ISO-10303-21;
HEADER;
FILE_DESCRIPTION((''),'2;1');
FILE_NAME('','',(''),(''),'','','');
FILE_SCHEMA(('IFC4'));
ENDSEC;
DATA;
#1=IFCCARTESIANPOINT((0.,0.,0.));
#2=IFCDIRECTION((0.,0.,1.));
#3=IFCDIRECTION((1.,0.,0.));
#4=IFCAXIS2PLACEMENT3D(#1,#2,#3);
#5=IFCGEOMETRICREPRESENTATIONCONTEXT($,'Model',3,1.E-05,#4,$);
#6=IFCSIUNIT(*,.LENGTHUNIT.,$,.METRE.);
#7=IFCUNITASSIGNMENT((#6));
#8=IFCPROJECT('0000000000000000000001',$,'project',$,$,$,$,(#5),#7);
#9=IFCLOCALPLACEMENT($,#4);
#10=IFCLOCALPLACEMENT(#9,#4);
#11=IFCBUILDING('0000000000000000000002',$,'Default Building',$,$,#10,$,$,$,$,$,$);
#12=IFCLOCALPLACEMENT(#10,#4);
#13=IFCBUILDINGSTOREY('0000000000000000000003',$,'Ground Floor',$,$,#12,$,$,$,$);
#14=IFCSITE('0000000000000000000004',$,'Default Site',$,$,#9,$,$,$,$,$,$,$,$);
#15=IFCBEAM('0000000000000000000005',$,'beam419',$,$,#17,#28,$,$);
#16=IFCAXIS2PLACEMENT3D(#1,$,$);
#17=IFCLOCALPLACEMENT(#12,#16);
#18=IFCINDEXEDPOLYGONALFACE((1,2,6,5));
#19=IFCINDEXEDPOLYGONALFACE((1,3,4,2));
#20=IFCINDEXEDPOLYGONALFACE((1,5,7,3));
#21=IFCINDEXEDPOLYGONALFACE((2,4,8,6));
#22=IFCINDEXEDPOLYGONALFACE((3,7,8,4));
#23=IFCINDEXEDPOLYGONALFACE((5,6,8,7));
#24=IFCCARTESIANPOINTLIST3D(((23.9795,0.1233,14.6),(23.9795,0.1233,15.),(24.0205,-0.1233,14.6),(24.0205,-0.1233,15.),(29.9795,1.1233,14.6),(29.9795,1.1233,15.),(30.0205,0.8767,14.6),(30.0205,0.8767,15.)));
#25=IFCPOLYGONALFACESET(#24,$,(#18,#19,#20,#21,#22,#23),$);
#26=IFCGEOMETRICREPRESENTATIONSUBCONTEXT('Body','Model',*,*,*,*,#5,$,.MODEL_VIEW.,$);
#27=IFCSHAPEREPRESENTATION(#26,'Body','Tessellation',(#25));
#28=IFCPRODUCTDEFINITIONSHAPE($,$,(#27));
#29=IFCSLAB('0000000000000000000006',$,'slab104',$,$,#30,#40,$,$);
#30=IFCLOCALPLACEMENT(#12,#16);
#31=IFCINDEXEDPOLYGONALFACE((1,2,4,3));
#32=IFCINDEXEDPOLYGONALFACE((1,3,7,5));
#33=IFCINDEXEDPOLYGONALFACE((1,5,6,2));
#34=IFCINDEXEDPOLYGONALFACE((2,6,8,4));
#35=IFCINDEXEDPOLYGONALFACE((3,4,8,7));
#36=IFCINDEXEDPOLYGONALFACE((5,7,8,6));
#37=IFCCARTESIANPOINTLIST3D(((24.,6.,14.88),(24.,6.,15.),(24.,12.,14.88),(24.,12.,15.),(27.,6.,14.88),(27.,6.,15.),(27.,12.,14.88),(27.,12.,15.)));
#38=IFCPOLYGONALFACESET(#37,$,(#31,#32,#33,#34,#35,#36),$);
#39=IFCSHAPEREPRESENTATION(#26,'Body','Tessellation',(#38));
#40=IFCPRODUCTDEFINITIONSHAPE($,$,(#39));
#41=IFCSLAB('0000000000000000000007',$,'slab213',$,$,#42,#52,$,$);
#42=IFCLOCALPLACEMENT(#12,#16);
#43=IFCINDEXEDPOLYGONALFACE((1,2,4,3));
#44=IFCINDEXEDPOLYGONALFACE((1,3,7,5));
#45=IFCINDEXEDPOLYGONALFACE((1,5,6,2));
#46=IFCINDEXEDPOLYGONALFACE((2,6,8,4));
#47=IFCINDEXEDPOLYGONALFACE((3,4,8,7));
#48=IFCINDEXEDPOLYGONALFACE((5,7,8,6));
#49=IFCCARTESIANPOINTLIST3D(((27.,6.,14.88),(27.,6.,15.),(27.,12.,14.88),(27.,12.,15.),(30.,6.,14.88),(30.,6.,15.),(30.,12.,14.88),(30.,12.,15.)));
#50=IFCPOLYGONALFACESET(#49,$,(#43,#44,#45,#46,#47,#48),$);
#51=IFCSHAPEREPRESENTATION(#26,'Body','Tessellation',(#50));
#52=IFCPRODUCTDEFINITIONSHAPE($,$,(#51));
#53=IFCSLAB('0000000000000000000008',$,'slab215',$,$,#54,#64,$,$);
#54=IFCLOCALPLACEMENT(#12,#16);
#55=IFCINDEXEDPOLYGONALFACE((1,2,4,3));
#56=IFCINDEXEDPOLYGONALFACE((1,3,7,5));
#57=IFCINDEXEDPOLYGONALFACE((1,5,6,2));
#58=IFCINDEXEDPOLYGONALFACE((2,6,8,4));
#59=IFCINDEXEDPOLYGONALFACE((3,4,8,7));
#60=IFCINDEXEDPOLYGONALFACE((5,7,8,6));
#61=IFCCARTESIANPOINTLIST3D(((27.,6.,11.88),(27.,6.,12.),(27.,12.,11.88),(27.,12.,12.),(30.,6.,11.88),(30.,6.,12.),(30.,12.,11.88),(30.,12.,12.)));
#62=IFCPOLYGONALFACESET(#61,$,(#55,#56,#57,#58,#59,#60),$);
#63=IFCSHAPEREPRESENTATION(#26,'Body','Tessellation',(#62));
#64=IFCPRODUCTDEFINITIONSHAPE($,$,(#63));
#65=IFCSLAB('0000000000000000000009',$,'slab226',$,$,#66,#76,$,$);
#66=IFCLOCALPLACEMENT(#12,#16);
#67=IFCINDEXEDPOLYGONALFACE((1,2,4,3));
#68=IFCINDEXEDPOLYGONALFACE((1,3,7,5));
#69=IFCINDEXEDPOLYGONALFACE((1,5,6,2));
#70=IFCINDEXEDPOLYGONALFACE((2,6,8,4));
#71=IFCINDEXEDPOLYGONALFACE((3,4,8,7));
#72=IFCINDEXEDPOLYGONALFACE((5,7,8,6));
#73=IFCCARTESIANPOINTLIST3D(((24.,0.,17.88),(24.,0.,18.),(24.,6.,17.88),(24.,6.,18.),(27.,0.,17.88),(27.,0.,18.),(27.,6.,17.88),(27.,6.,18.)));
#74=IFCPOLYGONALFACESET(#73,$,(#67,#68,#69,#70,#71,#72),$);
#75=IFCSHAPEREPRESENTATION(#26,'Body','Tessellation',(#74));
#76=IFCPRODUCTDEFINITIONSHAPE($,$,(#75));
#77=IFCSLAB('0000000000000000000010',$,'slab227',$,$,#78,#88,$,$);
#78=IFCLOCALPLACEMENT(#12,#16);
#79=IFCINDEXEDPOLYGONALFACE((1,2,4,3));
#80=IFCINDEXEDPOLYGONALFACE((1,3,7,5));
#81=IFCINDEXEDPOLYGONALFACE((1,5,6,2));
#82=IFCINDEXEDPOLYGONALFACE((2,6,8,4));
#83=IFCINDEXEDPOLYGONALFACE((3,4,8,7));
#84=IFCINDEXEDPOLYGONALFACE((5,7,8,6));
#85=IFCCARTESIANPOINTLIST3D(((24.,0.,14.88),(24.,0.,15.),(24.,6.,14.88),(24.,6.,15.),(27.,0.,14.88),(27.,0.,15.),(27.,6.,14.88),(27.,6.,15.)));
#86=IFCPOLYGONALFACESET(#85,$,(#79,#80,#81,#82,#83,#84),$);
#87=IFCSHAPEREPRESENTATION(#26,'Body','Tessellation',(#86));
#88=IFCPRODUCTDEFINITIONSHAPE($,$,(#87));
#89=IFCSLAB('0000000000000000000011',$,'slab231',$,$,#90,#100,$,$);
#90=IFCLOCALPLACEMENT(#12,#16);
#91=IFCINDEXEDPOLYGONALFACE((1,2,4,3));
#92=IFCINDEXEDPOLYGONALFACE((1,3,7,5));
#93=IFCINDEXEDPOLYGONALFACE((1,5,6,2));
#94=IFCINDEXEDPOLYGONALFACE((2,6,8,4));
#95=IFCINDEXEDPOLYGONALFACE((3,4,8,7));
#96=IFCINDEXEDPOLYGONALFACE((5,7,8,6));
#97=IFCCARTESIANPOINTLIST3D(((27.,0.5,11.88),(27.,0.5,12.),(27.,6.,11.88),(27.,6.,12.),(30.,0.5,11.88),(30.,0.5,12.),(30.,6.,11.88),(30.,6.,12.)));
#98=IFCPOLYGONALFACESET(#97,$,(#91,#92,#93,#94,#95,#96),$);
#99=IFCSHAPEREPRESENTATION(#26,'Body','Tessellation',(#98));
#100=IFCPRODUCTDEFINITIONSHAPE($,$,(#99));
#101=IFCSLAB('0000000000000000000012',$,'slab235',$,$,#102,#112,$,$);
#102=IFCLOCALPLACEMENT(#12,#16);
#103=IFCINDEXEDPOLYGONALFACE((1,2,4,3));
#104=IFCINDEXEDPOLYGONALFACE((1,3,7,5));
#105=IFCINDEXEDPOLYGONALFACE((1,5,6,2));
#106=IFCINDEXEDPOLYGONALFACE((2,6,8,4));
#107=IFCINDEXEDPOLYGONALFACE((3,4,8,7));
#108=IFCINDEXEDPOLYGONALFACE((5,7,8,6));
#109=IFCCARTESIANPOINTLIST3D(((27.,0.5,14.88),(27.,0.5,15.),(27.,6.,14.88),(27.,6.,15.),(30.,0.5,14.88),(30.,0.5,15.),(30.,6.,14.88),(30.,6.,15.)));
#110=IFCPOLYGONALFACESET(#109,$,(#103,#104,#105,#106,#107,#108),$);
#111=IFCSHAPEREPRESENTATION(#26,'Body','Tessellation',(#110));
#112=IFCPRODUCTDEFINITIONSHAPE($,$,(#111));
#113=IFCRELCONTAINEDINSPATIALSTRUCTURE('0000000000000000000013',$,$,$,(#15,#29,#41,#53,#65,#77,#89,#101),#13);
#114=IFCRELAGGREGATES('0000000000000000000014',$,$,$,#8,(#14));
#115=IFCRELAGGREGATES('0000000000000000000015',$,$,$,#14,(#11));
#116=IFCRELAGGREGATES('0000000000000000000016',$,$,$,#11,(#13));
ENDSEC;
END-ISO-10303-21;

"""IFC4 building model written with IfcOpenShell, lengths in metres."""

from ifc_helpers import new_model, si_unit, frame, origin_with_axes, place, context, subcontext, project, spatial, indexed_curve, outline, extrude, element, save


model = new_model("IFC4")

# Units and contexts
model_context = context("Model", 3, precision=1e-05, world=origin_with_axes())
body_context = subcontext(model_context, "Body", "Model", "MODEL_VIEW")
ifc_project = project(units=[si_unit("LENGTHUNIT", "METRE")], contexts=[model_context])

# Site, building, storey
site_placement = place(None, origin_with_axes())
site = spatial("IfcSite", under=ifc_project, at=site_placement, Name="Default Site")
building_placement = place(site_placement, origin_with_axes())
building = spatial("IfcBuilding", under=site, at=building_placement, Name="Default Building")
storey_placement = place(building_placement, origin_with_axes())
storey = spatial("IfcBuildingStorey", under=building, at=storey_placement, Name="Ground Floor")

# Beam
for number, where, z_axis, x_axis, name in (
    (1, (24.0205, -0.1233, 14.6), (0.0, 0.0, 1.0), (0.986394, 0.164399, 0.0), "beam419"),
):
    element("IfcBeam", number, at=place(storey_placement, frame(where, z_axis=z_axis, x_axis=x_axis)), inside=storey, Name=name, context=body_context, shape_type="SweptSolid", body=[
        extrude(outline(indexed_curve([(0.0, 0.0), (0.0, 0.25), (6.0828, 0.25), (6.0828, 0.0), (0.0, 0.0)], self_intersect=False)), origin_with_axes(), (0.0, 0.0, 1.0), 0.4),
    ])

# Slabs
for number, where, z_axis, x_axis, name in (
    (2, (24.0, 6.0, 14.88), (0.0, 0.0, 1.0), (1.0, 0.0, 0.0), "slab104"),
    (3, (27.0, 6.0, 14.88), (0.0, 0.0, 1.0), (1.0, 0.0, 0.0), "slab213"),
    (4, (27.0, 6.0, 11.88), (0.0, 0.0, 1.0), (1.0, 0.0, 0.0), "slab215"),
    (5, (24.0, 0.0, 17.88), (0.0, 0.0, 1.0), (1.0, 0.0, 0.0), "slab226"),
    (6, (24.0, 0.0, 14.88), (0.0, 0.0, 1.0), (1.0, 0.0, 0.0), "slab227"),
):
    element("IfcSlab", number, at=place(storey_placement, frame(where, z_axis=z_axis, x_axis=x_axis)), inside=storey, Name=name, context=body_context, shape_type="SweptSolid", body=[
        extrude(outline(indexed_curve([(0.0, 0.0), (0.0, 6.0), (3.0, 6.0), (3.0, 0.0), (0.0, 0.0)], self_intersect=False)), origin_with_axes(), (0.0, 0.0, 1.0), 0.12),
    ])
for number, where, z_axis, x_axis, name in (
    (7, (27.0, 0.5, 11.88), (0.0, 0.0, 1.0), (1.0, 0.0, 0.0), "slab231"),
    (8, (27.0, 0.5, 14.88), (0.0, 0.0, 1.0), (1.0, 0.0, 0.0), "slab235"),
):
    element("IfcSlab", number, at=place(storey_placement, frame(where, z_axis=z_axis, x_axis=x_axis)), inside=storey, Name=name, context=body_context, shape_type="SweptSolid", body=[
        extrude(outline(indexed_curve([(0.0, 0.0), (0.0, 5.5), (3.0, 5.5), (3.0, 0.0), (0.0, 0.0)], self_intersect=False)), origin_with_axes(), (0.0, 0.0, 1.0), 0.12),
    ])

save(model, "model.ifc")
